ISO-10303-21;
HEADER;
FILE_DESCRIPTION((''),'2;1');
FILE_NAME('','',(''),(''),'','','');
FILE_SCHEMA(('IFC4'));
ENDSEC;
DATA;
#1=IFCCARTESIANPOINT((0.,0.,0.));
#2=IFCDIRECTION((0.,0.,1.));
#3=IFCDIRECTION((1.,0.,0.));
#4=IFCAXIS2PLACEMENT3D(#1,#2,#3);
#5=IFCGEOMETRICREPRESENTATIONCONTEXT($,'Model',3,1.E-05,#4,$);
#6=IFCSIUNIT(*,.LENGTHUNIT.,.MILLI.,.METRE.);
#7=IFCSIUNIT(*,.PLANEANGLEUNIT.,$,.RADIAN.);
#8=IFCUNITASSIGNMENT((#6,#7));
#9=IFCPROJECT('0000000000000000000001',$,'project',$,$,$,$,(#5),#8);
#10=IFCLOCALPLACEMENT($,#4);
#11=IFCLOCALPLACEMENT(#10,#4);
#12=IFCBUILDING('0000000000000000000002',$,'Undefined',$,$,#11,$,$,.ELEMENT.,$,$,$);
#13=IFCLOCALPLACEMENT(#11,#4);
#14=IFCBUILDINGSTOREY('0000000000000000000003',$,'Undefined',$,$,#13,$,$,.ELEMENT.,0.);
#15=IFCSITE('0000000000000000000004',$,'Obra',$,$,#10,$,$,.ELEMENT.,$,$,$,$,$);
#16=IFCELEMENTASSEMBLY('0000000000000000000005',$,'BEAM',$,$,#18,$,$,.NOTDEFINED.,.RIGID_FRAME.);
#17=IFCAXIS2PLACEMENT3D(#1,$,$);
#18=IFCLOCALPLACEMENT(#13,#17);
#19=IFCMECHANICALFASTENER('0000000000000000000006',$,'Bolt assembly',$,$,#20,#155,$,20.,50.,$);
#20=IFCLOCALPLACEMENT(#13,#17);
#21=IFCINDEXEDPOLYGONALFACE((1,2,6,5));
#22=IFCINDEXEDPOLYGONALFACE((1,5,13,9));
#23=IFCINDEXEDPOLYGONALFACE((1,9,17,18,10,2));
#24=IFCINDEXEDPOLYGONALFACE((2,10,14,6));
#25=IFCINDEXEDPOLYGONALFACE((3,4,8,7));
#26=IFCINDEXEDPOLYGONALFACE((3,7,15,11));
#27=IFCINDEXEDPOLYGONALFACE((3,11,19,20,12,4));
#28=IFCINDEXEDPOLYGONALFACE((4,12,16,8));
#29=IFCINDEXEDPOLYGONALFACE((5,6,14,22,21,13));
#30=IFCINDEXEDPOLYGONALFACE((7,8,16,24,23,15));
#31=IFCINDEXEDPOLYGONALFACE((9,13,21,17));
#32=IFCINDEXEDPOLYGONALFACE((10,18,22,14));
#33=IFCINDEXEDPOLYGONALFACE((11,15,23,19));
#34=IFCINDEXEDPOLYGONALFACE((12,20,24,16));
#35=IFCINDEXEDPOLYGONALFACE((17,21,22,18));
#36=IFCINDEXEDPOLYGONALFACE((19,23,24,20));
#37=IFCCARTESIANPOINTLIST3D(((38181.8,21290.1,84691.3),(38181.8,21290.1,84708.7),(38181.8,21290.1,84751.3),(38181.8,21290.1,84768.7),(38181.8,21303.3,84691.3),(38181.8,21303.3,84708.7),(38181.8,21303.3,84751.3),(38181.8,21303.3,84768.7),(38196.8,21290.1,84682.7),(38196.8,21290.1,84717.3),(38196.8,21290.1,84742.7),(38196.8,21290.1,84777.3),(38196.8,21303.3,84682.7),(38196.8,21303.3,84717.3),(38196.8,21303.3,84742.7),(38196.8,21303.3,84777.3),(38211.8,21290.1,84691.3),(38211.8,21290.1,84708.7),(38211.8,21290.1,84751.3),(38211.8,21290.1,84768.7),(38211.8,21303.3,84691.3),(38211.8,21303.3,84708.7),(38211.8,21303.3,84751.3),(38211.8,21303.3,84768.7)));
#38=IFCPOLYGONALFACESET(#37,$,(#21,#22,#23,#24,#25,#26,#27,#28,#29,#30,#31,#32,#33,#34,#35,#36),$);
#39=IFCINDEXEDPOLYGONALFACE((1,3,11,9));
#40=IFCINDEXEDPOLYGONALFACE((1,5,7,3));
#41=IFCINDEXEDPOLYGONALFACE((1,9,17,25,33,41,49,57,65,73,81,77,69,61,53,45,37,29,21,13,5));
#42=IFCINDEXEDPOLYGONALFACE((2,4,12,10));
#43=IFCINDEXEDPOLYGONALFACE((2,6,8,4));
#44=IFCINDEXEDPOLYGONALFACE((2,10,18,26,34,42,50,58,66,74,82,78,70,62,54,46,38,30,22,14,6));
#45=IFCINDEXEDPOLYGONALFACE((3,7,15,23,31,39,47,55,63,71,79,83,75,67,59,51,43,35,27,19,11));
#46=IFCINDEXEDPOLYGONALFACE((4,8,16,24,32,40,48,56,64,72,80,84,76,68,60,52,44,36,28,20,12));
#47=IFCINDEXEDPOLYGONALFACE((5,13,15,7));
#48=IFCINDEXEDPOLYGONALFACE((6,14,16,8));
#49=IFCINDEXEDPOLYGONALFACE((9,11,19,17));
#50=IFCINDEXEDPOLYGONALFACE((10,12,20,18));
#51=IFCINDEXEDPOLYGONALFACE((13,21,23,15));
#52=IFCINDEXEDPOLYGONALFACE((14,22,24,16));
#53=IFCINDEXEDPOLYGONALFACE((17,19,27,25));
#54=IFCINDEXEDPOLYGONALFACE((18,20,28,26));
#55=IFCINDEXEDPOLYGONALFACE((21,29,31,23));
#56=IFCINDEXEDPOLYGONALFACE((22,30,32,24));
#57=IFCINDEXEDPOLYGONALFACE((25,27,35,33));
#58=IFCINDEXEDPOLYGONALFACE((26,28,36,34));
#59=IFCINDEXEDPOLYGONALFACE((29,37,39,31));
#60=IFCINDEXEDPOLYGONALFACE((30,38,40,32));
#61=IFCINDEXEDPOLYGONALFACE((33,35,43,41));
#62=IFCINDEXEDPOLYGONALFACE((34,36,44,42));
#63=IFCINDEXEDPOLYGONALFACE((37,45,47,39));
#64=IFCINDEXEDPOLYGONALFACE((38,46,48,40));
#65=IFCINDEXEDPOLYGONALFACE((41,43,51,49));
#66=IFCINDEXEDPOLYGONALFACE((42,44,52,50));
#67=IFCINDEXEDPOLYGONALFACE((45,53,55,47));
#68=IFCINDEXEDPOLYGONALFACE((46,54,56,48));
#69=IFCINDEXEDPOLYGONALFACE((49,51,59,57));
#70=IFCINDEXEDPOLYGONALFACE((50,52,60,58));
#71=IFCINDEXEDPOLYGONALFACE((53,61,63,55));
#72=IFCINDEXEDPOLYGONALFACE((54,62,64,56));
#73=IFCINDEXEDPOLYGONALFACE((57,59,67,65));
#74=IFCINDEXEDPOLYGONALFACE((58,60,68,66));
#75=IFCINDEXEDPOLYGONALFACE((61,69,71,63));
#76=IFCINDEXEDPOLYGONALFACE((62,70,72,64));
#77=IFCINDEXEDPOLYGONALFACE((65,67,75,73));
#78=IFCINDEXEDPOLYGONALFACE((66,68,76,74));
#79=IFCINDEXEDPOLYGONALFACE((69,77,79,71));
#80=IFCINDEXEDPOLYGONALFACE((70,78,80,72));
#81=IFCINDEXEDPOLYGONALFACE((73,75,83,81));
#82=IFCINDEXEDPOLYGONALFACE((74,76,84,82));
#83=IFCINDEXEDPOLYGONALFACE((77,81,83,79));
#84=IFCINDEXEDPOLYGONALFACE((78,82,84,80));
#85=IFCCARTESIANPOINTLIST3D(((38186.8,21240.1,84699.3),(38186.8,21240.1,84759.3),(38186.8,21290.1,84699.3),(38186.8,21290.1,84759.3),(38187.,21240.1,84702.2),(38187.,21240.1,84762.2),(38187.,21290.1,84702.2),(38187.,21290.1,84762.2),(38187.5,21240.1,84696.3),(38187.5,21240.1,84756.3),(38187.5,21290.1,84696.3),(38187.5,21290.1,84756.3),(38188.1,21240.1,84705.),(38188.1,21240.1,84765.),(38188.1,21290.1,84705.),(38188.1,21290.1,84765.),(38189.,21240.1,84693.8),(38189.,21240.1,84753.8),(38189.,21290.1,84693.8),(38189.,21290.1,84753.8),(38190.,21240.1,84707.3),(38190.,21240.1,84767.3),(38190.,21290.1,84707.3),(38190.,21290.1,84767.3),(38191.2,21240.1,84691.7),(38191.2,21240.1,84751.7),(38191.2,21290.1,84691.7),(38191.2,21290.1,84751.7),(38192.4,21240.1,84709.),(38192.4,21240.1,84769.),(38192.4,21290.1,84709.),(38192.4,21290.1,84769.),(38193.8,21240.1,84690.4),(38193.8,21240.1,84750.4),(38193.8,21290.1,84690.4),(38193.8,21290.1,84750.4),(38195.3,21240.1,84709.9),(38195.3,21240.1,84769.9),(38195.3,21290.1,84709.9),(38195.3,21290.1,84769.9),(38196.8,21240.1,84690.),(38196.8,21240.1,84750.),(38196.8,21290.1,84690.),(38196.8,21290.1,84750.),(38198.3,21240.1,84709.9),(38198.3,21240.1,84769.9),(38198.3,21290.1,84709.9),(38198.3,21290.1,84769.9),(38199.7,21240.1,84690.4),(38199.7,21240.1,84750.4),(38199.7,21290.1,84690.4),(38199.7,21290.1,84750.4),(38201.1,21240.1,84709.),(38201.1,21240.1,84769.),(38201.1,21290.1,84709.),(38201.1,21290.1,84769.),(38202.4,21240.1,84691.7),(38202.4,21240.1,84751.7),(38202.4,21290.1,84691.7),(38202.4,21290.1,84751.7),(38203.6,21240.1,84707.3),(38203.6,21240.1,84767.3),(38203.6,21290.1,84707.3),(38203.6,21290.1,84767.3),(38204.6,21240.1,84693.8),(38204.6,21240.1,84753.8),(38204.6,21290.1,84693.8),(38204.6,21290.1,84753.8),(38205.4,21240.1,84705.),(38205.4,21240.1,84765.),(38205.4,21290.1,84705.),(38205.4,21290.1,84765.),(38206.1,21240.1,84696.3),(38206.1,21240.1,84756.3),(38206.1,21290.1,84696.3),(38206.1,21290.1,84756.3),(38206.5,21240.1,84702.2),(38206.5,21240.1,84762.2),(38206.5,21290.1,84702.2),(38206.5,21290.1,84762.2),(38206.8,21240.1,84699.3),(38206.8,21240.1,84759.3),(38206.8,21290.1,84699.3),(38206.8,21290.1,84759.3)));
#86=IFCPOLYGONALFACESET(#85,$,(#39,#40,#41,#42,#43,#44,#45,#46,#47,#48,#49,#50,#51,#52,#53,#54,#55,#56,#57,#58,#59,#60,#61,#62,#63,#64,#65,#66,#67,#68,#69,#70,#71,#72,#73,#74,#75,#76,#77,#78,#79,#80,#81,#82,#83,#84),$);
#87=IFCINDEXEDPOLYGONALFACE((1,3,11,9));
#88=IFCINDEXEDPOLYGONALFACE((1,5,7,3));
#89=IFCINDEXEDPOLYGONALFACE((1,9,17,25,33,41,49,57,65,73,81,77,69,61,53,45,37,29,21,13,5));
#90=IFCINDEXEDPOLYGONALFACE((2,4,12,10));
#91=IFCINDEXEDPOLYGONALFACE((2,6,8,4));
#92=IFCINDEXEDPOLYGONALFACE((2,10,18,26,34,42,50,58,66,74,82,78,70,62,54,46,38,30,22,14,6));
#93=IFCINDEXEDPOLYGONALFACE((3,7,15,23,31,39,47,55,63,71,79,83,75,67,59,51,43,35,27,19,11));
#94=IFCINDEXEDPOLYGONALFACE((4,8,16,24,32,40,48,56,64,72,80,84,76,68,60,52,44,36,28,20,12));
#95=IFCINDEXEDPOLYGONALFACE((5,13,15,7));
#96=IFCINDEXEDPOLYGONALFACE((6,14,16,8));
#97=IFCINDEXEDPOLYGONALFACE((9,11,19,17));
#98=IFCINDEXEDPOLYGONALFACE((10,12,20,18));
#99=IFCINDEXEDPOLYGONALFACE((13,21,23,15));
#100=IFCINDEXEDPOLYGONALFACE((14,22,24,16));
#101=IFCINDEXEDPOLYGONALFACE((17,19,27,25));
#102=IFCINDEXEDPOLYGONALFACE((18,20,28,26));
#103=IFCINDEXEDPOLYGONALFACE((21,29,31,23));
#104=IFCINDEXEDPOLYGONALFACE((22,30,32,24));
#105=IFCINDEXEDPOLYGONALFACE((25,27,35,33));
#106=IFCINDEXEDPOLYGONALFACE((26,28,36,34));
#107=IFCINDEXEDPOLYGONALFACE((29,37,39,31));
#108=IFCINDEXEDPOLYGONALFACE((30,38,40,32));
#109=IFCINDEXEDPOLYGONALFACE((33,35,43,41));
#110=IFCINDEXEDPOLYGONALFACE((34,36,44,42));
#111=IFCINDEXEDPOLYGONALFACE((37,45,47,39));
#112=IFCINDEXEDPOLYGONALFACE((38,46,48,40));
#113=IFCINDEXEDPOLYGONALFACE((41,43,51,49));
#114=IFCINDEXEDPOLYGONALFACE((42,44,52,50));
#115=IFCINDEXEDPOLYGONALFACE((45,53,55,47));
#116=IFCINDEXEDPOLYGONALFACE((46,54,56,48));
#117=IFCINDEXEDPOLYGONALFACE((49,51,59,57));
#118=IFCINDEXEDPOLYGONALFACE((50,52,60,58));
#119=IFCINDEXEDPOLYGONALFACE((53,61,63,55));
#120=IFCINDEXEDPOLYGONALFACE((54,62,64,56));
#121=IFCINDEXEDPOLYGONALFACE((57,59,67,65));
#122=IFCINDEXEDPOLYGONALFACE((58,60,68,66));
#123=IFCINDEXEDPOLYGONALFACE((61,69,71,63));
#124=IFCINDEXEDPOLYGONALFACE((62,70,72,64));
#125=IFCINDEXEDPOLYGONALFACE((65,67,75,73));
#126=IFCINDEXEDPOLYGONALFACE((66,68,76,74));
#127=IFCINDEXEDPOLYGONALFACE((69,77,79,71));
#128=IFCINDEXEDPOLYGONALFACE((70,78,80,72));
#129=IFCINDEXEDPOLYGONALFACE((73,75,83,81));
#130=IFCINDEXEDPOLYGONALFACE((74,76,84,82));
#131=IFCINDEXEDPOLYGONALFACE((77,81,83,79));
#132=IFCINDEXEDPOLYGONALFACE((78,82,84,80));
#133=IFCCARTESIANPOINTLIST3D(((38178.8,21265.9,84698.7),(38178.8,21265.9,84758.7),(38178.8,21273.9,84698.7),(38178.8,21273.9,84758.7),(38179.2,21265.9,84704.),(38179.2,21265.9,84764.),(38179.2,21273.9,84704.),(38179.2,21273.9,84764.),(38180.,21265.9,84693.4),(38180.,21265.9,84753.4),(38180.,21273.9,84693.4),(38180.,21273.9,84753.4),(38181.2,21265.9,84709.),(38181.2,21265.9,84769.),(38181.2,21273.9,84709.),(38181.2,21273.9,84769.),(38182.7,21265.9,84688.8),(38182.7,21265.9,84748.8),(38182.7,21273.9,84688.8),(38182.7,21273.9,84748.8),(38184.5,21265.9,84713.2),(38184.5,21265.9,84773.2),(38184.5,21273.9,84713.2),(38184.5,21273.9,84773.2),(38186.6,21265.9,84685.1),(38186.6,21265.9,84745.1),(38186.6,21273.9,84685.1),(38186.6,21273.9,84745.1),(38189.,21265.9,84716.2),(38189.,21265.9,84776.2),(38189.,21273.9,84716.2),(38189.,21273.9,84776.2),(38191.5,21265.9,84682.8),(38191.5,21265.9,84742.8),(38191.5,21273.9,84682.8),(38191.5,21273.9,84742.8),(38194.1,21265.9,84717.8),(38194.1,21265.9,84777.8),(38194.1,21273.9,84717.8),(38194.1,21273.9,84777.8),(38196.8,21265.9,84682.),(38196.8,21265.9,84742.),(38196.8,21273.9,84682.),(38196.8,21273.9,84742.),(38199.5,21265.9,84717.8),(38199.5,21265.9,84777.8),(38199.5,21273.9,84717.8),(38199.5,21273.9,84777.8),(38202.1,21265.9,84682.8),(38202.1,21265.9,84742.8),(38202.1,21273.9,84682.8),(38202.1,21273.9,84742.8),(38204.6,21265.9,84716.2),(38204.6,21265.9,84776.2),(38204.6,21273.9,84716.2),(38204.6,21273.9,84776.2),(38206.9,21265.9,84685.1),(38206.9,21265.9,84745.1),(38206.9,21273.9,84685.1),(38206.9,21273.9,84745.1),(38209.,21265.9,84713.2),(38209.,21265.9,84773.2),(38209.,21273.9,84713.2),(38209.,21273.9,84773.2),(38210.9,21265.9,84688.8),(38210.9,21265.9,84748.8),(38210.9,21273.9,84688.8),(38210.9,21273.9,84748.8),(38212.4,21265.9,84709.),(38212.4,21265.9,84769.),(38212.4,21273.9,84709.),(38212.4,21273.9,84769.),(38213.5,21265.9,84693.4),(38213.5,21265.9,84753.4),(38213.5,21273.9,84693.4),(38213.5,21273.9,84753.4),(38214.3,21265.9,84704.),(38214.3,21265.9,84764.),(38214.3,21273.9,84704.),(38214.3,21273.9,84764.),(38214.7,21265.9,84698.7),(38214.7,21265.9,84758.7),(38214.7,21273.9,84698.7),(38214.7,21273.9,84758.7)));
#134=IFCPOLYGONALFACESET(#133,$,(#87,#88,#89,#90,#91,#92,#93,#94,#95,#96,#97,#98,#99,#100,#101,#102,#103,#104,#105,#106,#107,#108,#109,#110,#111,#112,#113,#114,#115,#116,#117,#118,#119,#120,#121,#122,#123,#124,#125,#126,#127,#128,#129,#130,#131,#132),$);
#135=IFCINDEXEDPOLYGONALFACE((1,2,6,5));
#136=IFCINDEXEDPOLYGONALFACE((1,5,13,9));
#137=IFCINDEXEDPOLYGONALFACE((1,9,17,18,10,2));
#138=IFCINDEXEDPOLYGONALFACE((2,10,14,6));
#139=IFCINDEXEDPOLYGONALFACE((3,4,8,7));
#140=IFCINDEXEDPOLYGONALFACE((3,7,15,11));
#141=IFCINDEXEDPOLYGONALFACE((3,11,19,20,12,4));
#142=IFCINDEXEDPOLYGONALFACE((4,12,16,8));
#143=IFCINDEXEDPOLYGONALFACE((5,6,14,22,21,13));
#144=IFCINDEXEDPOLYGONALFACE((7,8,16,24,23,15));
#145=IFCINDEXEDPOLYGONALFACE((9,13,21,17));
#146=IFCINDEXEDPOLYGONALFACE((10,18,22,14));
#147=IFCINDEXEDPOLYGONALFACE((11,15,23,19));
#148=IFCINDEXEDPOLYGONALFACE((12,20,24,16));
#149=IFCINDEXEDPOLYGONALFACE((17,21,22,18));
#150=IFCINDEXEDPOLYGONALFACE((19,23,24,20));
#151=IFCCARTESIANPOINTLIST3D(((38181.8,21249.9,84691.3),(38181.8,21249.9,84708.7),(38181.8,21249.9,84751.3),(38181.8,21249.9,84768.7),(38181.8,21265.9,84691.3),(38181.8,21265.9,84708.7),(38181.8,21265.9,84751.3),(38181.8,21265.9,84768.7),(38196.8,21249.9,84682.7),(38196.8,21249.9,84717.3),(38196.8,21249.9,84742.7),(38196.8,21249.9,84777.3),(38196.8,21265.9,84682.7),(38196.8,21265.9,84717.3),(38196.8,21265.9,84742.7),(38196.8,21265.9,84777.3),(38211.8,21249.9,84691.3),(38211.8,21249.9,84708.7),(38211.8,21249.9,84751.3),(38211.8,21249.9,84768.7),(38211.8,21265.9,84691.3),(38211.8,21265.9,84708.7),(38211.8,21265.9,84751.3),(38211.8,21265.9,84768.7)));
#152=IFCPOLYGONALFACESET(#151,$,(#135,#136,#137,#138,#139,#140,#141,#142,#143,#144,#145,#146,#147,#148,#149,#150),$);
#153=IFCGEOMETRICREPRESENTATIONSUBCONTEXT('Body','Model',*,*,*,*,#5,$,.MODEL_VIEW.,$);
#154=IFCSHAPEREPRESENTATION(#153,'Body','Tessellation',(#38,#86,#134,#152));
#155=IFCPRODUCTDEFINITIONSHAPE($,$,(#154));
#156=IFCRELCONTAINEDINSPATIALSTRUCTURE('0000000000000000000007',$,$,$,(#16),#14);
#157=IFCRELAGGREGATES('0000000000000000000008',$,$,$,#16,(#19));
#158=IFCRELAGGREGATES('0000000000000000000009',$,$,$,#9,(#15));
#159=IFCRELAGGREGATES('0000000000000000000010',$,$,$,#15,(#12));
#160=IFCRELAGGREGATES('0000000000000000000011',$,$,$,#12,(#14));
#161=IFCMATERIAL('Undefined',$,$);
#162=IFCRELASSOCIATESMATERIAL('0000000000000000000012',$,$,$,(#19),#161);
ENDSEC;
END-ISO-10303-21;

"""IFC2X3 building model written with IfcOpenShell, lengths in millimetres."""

from ifc_helpers import new_model, si_unit, frame, origin_with_axes, origin_2d_with_axis, place, context, subcontext, project, spatial, polyline, circle, outline, extrude, source, transform, mapped, material, element, aggregate, save


model = new_model("IFC2X3")

# Units and contexts
model_context = context("Model", 3, precision=1e-05, world=origin_with_axes())
body_context = subcontext(model_context, "Body", "Model", "MODEL_VIEW")
ifc_project = project(units=[si_unit("LENGTHUNIT", "METRE", prefix="MILLI"), si_unit("PLANEANGLEUNIT", "RADIAN")], contexts=[model_context])

# Site, building, storey
site_placement = place(None, origin_with_axes())
site = spatial("IfcSite", under=ifc_project, at=site_placement, Name="Obra", CompositionType="ELEMENT")
building_placement = place(site_placement, origin_with_axes())
building = spatial("IfcBuilding", under=site, at=building_placement, Name="Undefined", CompositionType="ELEMENT")
storey_placement = place(building_placement, origin_with_axes())
storey = spatial("IfcBuildingStorey", under=building, at=storey_placement, Name="Undefined", CompositionType="ELEMENT", Elevation=0.0)

# Shared definitions
ifc_material_1 = material(Name="Undefined")

# Element assembly
assembly_1_placement = place(storey_placement, origin_with_axes())
assembly_1 = element("IfcElementAssembly", 1, at=assembly_1_placement, inside=storey, Name="BEAM", AssemblyPlace="NOTDEFINED", PredefinedType="RIGID_FRAME")

# Mechanical fastener
shared_shape_1 = source(origin_with_axes(), body_context, "Body", "SweptSolid", [
    extrude(outline(polyline([(17.3, 0.0), (8.7, 15.0), (-8.7, 15.0), (-17.3, 0.0), (-8.7, -15.0), (8.7, -15.0), (17.3, 0.0)])), frame((0.0, -26.3, 0.0), z_axis=(0.0, 1.0, 0.0), x_axis=(1.0, 0.0, 0.0)), (0.0, 0.0, 1.0), 13.2),
    extrude(circle(Radius=10.0, at=origin_2d_with_axis()), frame((0.0, -13.1, 0.0), z_axis=(0.0, 1.0, 0.0), x_axis=(1.0, 0.0, 0.0)), (0.0, 0.0, 1.0), 50.0),
    extrude(circle(Radius=18.0, at=origin_2d_with_axis()), frame((0.0, 3.1, 0.0), z_axis=(0.0, 1.0, 0.0), x_axis=(1.0, 0.0, 0.0)), (0.0, 0.0, 1.0), 8.0),
    extrude(outline(polyline([(17.3, 0.0), (8.7, 15.0), (-8.7, 15.0), (-17.3, 0.0), (-8.7, -15.0), (8.7, -15.0), (17.3, 0.0)])), frame((0.0, 11.1, 0.0), z_axis=(0.0, 1.0, 0.0), x_axis=(1.0, 0.0, 0.0)), (0.0, 0.0, 1.0), 16.0),
])
mechanical_fastener_1_placement = place(assembly_1_placement, frame((38236.8, 21277.0, 84850.0), z_axis=(-1.0, 0.0, 0.0), x_axis=(0.0, 0.0, -1.0)))
mechanical_fastener_1 = element("IfcMechanicalFastener", 2, at=mechanical_fastener_1_placement, material=ifc_material_1, Name="Bolt assembly", NominalDiameter=20.0, NominalLength=50.0, context=body_context, shape_type="MappedRepresentation", body=[
    mapped(shared_shape_1, transform((90.0, 0.0, 40.0))),
    mapped(shared_shape_1, transform((150.0, 0.0, 40.0))),
])
aggregate(assembly_1, [mechanical_fastener_1])

save(model, "model.ifc")
